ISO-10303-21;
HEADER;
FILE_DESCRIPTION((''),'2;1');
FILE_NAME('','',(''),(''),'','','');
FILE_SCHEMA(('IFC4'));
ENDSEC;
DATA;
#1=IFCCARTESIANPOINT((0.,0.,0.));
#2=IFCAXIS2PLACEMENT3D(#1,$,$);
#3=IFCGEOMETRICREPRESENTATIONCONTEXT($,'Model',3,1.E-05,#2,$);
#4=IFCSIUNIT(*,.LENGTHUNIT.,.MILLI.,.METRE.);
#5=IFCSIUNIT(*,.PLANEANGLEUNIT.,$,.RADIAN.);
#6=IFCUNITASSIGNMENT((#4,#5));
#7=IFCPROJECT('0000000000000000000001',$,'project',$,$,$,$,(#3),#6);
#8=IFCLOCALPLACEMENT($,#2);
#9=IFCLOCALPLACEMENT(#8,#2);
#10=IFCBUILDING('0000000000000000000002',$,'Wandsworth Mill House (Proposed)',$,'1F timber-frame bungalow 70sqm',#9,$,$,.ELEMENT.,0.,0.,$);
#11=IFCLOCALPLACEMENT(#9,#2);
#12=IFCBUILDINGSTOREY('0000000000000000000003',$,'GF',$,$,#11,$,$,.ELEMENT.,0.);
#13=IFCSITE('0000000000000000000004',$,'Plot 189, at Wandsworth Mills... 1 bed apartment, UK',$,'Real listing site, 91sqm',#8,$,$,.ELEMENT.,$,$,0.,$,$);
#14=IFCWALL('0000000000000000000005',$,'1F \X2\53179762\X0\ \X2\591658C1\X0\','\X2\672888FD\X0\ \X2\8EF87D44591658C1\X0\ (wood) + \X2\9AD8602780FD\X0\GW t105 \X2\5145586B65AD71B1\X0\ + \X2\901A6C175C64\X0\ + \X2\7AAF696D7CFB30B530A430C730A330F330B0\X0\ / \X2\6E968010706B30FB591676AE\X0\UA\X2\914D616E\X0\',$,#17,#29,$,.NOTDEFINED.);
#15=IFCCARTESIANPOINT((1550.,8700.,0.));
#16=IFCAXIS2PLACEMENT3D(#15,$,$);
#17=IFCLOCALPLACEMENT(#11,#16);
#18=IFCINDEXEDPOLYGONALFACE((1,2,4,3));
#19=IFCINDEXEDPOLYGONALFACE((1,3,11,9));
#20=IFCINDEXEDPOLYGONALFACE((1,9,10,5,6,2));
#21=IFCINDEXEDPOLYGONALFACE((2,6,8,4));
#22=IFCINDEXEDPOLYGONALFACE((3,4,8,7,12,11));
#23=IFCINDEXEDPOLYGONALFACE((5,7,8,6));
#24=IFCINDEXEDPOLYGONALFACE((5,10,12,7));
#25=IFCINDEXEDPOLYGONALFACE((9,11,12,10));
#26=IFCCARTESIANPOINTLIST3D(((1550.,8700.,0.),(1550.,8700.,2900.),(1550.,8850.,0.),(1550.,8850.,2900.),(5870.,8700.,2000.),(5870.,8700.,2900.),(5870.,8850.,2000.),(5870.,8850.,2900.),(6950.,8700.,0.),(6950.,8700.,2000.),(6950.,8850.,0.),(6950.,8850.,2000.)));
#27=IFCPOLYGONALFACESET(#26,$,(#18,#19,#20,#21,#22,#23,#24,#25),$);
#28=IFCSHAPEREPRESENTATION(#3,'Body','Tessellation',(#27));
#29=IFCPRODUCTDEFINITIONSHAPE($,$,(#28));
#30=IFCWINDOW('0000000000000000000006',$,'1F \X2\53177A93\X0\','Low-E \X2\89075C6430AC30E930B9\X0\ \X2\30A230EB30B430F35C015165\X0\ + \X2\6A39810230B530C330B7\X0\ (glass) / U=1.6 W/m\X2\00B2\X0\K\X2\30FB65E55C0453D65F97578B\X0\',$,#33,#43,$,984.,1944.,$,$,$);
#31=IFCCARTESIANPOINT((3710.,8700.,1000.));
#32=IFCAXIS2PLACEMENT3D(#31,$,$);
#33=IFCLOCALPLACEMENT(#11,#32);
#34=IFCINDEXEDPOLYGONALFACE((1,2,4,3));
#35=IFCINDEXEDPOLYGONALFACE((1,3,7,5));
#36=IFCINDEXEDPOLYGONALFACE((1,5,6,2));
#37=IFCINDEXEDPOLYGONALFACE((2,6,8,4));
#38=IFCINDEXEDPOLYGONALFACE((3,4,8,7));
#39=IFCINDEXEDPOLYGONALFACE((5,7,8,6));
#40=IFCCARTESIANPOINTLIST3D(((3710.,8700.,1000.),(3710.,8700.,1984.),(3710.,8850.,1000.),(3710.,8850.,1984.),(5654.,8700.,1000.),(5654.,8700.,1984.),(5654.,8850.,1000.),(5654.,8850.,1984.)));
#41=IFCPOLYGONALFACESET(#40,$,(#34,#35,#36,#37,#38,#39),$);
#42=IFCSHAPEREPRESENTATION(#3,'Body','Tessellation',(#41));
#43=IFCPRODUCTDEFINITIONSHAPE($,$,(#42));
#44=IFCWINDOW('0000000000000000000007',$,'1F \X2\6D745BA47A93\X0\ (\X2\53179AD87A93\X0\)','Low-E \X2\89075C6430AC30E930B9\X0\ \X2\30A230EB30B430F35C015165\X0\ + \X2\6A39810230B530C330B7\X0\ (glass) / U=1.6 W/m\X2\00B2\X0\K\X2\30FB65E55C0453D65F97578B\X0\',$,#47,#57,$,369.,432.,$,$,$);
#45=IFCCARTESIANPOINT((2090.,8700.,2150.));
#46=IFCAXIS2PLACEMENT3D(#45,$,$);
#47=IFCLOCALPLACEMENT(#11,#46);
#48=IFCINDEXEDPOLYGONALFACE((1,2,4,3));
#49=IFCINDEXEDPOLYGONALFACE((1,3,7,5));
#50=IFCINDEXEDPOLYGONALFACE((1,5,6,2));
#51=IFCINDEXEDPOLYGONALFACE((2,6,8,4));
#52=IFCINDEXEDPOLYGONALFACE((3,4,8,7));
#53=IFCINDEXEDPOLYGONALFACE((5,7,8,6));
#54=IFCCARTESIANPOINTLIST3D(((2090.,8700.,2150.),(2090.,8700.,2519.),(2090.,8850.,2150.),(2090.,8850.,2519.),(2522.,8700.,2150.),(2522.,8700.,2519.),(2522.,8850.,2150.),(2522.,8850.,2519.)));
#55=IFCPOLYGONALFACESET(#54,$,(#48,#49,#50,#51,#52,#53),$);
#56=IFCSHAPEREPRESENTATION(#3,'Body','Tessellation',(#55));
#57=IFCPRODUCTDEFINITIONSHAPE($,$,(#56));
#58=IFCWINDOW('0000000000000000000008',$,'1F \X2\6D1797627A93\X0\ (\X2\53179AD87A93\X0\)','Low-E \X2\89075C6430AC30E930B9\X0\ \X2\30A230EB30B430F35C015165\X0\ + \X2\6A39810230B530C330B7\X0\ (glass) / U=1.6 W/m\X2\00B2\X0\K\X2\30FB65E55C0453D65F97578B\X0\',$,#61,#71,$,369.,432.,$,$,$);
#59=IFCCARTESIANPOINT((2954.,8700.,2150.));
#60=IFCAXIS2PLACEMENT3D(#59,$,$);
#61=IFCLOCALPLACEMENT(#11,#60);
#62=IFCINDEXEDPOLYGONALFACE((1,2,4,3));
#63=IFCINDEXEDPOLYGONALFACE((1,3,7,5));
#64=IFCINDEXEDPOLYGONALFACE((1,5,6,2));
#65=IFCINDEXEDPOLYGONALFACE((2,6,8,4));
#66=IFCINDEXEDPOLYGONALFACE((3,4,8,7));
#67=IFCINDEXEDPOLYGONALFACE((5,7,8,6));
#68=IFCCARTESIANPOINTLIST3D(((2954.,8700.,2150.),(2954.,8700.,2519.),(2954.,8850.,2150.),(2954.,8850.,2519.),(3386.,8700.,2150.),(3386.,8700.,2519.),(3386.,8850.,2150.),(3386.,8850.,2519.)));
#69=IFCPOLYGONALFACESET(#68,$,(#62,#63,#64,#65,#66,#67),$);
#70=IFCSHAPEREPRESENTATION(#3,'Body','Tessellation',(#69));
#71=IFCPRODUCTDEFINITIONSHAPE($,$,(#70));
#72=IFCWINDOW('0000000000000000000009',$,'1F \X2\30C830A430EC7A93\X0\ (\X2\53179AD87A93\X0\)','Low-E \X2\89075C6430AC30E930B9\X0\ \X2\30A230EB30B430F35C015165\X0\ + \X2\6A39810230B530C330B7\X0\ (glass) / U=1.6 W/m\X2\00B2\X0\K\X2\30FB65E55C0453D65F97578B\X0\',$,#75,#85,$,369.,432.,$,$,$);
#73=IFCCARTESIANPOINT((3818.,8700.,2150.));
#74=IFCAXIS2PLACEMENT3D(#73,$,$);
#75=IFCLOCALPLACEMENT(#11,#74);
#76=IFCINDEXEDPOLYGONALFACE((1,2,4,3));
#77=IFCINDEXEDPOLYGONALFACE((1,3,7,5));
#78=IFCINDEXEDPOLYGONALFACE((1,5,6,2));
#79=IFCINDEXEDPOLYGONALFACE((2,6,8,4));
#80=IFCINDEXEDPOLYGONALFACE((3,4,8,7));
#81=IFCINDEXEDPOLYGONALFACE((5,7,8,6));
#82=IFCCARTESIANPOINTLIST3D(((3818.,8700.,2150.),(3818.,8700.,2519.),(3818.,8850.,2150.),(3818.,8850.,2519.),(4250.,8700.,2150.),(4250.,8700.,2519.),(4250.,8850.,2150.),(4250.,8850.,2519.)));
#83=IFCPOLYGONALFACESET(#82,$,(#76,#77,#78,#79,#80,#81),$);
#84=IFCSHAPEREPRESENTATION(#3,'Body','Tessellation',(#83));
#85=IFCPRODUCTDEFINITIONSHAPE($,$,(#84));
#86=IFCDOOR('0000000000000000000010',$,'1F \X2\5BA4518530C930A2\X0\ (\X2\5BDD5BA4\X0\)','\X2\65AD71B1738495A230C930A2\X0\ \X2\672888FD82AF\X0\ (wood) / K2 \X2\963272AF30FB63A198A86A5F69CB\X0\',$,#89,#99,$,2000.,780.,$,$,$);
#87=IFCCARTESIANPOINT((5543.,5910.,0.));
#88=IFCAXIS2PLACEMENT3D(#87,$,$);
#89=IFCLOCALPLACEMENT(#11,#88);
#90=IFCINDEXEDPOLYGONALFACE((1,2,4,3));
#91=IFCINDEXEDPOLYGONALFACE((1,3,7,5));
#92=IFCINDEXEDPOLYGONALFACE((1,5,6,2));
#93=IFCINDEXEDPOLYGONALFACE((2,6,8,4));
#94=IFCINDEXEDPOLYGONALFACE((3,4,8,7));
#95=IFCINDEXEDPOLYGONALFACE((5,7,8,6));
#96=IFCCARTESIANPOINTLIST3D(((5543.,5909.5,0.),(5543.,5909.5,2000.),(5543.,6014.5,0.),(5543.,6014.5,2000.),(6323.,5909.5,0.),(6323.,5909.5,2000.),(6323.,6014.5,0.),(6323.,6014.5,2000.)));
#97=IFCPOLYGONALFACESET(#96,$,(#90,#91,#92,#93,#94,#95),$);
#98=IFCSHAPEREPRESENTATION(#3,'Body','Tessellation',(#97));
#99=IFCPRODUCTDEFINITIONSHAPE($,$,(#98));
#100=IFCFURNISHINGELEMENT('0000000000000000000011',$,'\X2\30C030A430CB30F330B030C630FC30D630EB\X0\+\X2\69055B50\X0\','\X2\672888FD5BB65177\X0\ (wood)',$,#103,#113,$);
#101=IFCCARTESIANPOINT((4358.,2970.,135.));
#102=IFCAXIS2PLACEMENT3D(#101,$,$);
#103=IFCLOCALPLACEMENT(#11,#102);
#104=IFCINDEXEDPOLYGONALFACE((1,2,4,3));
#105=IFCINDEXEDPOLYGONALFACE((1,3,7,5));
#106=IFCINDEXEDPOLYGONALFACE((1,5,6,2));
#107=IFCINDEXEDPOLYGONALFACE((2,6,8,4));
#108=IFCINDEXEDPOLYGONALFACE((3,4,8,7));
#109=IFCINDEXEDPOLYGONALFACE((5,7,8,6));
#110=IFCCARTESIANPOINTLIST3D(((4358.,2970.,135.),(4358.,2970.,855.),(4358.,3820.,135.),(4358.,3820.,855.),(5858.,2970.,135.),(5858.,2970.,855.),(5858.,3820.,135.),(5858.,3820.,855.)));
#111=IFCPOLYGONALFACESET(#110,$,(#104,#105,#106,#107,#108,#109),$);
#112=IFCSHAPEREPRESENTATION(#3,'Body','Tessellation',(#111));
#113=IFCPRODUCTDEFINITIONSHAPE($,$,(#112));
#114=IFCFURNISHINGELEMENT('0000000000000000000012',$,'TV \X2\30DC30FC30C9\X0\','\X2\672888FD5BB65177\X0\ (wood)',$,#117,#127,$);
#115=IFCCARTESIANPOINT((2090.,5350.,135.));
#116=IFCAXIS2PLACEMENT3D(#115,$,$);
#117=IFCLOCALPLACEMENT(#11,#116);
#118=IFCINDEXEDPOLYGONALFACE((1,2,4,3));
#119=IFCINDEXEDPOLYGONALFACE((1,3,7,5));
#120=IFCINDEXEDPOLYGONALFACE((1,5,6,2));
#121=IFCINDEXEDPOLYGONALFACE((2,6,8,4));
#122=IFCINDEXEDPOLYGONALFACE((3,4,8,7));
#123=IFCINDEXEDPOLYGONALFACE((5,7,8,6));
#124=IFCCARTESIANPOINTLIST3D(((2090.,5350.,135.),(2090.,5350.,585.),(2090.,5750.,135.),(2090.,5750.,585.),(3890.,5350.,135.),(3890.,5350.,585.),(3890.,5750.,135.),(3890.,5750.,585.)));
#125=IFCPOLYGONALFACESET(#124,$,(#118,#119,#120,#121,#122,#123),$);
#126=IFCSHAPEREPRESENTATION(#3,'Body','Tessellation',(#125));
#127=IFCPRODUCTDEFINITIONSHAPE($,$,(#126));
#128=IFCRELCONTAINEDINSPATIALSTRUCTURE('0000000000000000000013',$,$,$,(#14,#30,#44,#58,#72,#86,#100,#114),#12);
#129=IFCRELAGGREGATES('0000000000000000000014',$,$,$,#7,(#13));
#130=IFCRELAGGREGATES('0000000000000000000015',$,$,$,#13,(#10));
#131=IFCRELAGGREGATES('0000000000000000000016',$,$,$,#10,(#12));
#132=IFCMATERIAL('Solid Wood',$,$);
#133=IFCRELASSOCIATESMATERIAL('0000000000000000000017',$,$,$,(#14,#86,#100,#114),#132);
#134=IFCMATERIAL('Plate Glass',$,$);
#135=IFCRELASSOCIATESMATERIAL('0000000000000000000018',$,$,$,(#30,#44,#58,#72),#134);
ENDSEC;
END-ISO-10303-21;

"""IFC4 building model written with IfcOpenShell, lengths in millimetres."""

from ifc_helpers import new_model, si_unit, frame, frame_2d, origin, place, context, project, spatial, rectangle, extrude, material, element, fill, save


model = new_model("IFC4")

# Units and contexts
model_context = context("Model", 3, precision=1e-05, world=origin())
ifc_project = project(units=[si_unit("LENGTHUNIT", "METRE", prefix="MILLI"), si_unit("PLANEANGLEUNIT", "RADIAN")], contexts=[model_context])

# Site, building, storey
site_placement = place(None, origin())
site = spatial("IfcSite", under=ifc_project, at=site_placement, Name="Plot 189, at Wandsworth Mills... 1 bed apartment, UK", ObjectType="Real listing site, 91sqm", CompositionType="ELEMENT", RefElevation=0.0)
building_placement = place(site_placement, origin())
building = spatial("IfcBuilding", under=site, at=building_placement, Name="Wandsworth Mill House (Proposed)", ObjectType="1F timber-frame bungalow 70sqm", CompositionType="ELEMENT", ElevationOfRefHeight=0.0, ElevationOfTerrain=0.0)
storey_placement = place(building_placement, origin())
storey = spatial("IfcBuildingStorey", under=building, at=storey_placement, Name="GF", CompositionType="ELEMENT", Elevation=0.0)

# Wall, openings, windows
ifc_material_1 = material(Name="Solid Wood")
wall_1_placement = place(storey_placement, frame((1550.0, 8700.0, 0.0)))
wall_1 = element("IfcWall", 1, at=wall_1_placement, inside=storey, material=ifc_material_1, Name="1F 北面 外壁", Description="木製 軸組外壁 (wood) + 高性能GW t105 充填断熱 + 通気層 + 窯業系サイディング / 準耐火・外皮UA配慮", PredefinedType="NOTDEFINED", context=model_context, shape_type="SweptSolid", body=[
    extrude(rectangle(XDim=5400.0, YDim=150.0, at=frame_2d((2700.0, 75.0))), frame((1550.0, 8700.0, 0.0)), (0.0, 0.0, 1.0), 2900.0),
])
opening_1_placement = place(storey_placement, frame((3710.0, 8700.0, 1000.0)))
opening_1 = element("IfcOpeningElement", 2, at=opening_1_placement, cuts=wall_1, PredefinedType="NOTDEFINED", context=model_context, shape_type="SweptSolid", body=[
    extrude(rectangle(XDim=1944.0, YDim=150.0, at=frame_2d((972.0, 75.0))), frame((3710.0, 8700.0, 1000.0)), (0.0, 0.0, 1.0), 984.0),
])
opening_2_placement = place(storey_placement, frame((2090.0, 8700.0, 2150.0)))
opening_2 = element("IfcOpeningElement", 3, at=opening_2_placement, cuts=wall_1, PredefinedType="NOTDEFINED", context=model_context, shape_type="SweptSolid", body=[
    extrude(rectangle(XDim=432.0, YDim=150.0, at=frame_2d((216.0, 75.0))), frame((2090.0, 8700.0, 2150.0)), (0.0, 0.0, 1.0), 369.0),
])
opening_3_placement = place(storey_placement, frame((2954.0, 8700.0, 2150.0)))
opening_3 = element("IfcOpeningElement", 4, at=opening_3_placement, cuts=wall_1, PredefinedType="NOTDEFINED", context=model_context, shape_type="SweptSolid", body=[
    extrude(rectangle(XDim=432.0, YDim=150.0, at=frame_2d((216.0, 75.0))), frame((2954.0, 8700.0, 2150.0)), (0.0, 0.0, 1.0), 369.0),
])
opening_4_placement = place(storey_placement, frame((3818.0, 8700.0, 2150.0)))
opening_4 = element("IfcOpeningElement", 5, at=opening_4_placement, cuts=wall_1, PredefinedType="NOTDEFINED", context=model_context, shape_type="SweptSolid", body=[
    extrude(rectangle(XDim=432.0, YDim=150.0, at=frame_2d((216.0, 75.0))), frame((3818.0, 8700.0, 2150.0)), (0.0, 0.0, 1.0), 369.0),
])
ifc_material_2 = material(Name="Plate Glass")
window_1_placement = place(storey_placement, frame((3710.0, 8700.0, 1000.0)))
window_1 = element("IfcWindow", 6, at=window_1_placement, inside=storey, material=ifc_material_2, Name="1F 北窓", Description="Low-E 複層ガラス アルゴン封入 + 樹脂サッシ (glass) / U=1.6 W/m²K・日射取得型", OverallHeight=984.0, OverallWidth=1944.0, context=model_context, shape_type="SweptSolid", body=[
    extrude(rectangle(XDim=1944.0, YDim=150.0, at=frame_2d((972.0, 75.0))), frame((3710.0, 8700.0, 1000.0)), (0.0, 0.0, 1.0), 984.0),
])
fill(opening_1, window_1)
window_2_placement = place(storey_placement, frame((2090.0, 8700.0, 2150.0)))
window_2 = element("IfcWindow", 7, at=window_2_placement, inside=storey, material=ifc_material_2, Name="1F 浴室窓 (北高窓)", Description="Low-E 複層ガラス アルゴン封入 + 樹脂サッシ (glass) / U=1.6 W/m²K・日射取得型", OverallHeight=369.0, OverallWidth=432.0, context=model_context, shape_type="SweptSolid", body=[
    extrude(rectangle(XDim=432.0, YDim=150.0, at=frame_2d((216.0, 75.0))), frame((2090.0, 8700.0, 2150.0)), (0.0, 0.0, 1.0), 369.0),
])
fill(opening_2, window_2)
window_3_placement = place(storey_placement, frame((2954.0, 8700.0, 2150.0)))
window_3 = element("IfcWindow", 8, at=window_3_placement, inside=storey, material=ifc_material_2, Name="1F 洗面窓 (北高窓)", Description="Low-E 複層ガラス アルゴン封入 + 樹脂サッシ (glass) / U=1.6 W/m²K・日射取得型", OverallHeight=369.0, OverallWidth=432.0, context=model_context, shape_type="SweptSolid", body=[
    extrude(rectangle(XDim=432.0, YDim=150.0, at=frame_2d((216.0, 75.0))), frame((2954.0, 8700.0, 2150.0)), (0.0, 0.0, 1.0), 369.0),
])
fill(opening_3, window_3)
window_4_placement = place(storey_placement, frame((3818.0, 8700.0, 2150.0)))
window_4 = element("IfcWindow", 9, at=window_4_placement, inside=storey, material=ifc_material_2, Name="1F トイレ窓 (北高窓)", Description="Low-E 複層ガラス アルゴン封入 + 樹脂サッシ (glass) / U=1.6 W/m²K・日射取得型", OverallHeight=369.0, OverallWidth=432.0, context=model_context, shape_type="SweptSolid", body=[
    extrude(rectangle(XDim=432.0, YDim=150.0, at=frame_2d((216.0, 75.0))), frame((3818.0, 8700.0, 2150.0)), (0.0, 0.0, 1.0), 369.0),
])
fill(opening_4, window_4)

# Door
door_1_placement = place(storey_placement, frame((5543.0, 5910.0, 0.0)))
element("IfcDoor", 10, at=door_1_placement, inside=storey, material=ifc_material_1, Name="1F 室内ドア (寝室)", Description="断熱玄関ドア 木製芯 (wood) / K2 防犯・採風機構", OverallHeight=2000.0, OverallWidth=780.0, context=model_context, shape_type="SweptSolid", body=[
    extrude(rectangle(XDim=780.0, YDim=105.0, at=frame_2d((390.0, 52.0))), frame((5543.0, 5910.0, 0.0)), (0.0, 0.0, 1.0), 2000.0),
])

# Furnishing elements
furnishing_1_placement = place(storey_placement, frame((4358.0, 2970.0, 135.0)))
element("IfcFurnishingElement", 11, at=furnishing_1_placement, inside=storey, material=ifc_material_1, Name="ダイニングテーブル+椅子", Description="木製家具 (wood)", context=model_context, shape_type="SweptSolid", body=[
    extrude(rectangle(XDim=1500.0, YDim=850.0, at=frame_2d((750.0, 425.0))), frame((4358.0, 2970.0, 135.0)), (0.0, 0.0, 1.0), 720.0),
])
furnishing_2_placement = place(storey_placement, frame((2090.0, 5350.0, 135.0)))
element("IfcFurnishingElement", 12, at=furnishing_2_placement, inside=storey, material=ifc_material_1, Name="TV ボード", Description="木製家具 (wood)", context=model_context, shape_type="SweptSolid", body=[
    extrude(rectangle(XDim=1800.0, YDim=400.0, at=frame_2d((900.0, 200.0))), frame((2090.0, 5350.0, 135.0)), (0.0, 0.0, 1.0), 450.0),
])

save(model, "model.ifc")
